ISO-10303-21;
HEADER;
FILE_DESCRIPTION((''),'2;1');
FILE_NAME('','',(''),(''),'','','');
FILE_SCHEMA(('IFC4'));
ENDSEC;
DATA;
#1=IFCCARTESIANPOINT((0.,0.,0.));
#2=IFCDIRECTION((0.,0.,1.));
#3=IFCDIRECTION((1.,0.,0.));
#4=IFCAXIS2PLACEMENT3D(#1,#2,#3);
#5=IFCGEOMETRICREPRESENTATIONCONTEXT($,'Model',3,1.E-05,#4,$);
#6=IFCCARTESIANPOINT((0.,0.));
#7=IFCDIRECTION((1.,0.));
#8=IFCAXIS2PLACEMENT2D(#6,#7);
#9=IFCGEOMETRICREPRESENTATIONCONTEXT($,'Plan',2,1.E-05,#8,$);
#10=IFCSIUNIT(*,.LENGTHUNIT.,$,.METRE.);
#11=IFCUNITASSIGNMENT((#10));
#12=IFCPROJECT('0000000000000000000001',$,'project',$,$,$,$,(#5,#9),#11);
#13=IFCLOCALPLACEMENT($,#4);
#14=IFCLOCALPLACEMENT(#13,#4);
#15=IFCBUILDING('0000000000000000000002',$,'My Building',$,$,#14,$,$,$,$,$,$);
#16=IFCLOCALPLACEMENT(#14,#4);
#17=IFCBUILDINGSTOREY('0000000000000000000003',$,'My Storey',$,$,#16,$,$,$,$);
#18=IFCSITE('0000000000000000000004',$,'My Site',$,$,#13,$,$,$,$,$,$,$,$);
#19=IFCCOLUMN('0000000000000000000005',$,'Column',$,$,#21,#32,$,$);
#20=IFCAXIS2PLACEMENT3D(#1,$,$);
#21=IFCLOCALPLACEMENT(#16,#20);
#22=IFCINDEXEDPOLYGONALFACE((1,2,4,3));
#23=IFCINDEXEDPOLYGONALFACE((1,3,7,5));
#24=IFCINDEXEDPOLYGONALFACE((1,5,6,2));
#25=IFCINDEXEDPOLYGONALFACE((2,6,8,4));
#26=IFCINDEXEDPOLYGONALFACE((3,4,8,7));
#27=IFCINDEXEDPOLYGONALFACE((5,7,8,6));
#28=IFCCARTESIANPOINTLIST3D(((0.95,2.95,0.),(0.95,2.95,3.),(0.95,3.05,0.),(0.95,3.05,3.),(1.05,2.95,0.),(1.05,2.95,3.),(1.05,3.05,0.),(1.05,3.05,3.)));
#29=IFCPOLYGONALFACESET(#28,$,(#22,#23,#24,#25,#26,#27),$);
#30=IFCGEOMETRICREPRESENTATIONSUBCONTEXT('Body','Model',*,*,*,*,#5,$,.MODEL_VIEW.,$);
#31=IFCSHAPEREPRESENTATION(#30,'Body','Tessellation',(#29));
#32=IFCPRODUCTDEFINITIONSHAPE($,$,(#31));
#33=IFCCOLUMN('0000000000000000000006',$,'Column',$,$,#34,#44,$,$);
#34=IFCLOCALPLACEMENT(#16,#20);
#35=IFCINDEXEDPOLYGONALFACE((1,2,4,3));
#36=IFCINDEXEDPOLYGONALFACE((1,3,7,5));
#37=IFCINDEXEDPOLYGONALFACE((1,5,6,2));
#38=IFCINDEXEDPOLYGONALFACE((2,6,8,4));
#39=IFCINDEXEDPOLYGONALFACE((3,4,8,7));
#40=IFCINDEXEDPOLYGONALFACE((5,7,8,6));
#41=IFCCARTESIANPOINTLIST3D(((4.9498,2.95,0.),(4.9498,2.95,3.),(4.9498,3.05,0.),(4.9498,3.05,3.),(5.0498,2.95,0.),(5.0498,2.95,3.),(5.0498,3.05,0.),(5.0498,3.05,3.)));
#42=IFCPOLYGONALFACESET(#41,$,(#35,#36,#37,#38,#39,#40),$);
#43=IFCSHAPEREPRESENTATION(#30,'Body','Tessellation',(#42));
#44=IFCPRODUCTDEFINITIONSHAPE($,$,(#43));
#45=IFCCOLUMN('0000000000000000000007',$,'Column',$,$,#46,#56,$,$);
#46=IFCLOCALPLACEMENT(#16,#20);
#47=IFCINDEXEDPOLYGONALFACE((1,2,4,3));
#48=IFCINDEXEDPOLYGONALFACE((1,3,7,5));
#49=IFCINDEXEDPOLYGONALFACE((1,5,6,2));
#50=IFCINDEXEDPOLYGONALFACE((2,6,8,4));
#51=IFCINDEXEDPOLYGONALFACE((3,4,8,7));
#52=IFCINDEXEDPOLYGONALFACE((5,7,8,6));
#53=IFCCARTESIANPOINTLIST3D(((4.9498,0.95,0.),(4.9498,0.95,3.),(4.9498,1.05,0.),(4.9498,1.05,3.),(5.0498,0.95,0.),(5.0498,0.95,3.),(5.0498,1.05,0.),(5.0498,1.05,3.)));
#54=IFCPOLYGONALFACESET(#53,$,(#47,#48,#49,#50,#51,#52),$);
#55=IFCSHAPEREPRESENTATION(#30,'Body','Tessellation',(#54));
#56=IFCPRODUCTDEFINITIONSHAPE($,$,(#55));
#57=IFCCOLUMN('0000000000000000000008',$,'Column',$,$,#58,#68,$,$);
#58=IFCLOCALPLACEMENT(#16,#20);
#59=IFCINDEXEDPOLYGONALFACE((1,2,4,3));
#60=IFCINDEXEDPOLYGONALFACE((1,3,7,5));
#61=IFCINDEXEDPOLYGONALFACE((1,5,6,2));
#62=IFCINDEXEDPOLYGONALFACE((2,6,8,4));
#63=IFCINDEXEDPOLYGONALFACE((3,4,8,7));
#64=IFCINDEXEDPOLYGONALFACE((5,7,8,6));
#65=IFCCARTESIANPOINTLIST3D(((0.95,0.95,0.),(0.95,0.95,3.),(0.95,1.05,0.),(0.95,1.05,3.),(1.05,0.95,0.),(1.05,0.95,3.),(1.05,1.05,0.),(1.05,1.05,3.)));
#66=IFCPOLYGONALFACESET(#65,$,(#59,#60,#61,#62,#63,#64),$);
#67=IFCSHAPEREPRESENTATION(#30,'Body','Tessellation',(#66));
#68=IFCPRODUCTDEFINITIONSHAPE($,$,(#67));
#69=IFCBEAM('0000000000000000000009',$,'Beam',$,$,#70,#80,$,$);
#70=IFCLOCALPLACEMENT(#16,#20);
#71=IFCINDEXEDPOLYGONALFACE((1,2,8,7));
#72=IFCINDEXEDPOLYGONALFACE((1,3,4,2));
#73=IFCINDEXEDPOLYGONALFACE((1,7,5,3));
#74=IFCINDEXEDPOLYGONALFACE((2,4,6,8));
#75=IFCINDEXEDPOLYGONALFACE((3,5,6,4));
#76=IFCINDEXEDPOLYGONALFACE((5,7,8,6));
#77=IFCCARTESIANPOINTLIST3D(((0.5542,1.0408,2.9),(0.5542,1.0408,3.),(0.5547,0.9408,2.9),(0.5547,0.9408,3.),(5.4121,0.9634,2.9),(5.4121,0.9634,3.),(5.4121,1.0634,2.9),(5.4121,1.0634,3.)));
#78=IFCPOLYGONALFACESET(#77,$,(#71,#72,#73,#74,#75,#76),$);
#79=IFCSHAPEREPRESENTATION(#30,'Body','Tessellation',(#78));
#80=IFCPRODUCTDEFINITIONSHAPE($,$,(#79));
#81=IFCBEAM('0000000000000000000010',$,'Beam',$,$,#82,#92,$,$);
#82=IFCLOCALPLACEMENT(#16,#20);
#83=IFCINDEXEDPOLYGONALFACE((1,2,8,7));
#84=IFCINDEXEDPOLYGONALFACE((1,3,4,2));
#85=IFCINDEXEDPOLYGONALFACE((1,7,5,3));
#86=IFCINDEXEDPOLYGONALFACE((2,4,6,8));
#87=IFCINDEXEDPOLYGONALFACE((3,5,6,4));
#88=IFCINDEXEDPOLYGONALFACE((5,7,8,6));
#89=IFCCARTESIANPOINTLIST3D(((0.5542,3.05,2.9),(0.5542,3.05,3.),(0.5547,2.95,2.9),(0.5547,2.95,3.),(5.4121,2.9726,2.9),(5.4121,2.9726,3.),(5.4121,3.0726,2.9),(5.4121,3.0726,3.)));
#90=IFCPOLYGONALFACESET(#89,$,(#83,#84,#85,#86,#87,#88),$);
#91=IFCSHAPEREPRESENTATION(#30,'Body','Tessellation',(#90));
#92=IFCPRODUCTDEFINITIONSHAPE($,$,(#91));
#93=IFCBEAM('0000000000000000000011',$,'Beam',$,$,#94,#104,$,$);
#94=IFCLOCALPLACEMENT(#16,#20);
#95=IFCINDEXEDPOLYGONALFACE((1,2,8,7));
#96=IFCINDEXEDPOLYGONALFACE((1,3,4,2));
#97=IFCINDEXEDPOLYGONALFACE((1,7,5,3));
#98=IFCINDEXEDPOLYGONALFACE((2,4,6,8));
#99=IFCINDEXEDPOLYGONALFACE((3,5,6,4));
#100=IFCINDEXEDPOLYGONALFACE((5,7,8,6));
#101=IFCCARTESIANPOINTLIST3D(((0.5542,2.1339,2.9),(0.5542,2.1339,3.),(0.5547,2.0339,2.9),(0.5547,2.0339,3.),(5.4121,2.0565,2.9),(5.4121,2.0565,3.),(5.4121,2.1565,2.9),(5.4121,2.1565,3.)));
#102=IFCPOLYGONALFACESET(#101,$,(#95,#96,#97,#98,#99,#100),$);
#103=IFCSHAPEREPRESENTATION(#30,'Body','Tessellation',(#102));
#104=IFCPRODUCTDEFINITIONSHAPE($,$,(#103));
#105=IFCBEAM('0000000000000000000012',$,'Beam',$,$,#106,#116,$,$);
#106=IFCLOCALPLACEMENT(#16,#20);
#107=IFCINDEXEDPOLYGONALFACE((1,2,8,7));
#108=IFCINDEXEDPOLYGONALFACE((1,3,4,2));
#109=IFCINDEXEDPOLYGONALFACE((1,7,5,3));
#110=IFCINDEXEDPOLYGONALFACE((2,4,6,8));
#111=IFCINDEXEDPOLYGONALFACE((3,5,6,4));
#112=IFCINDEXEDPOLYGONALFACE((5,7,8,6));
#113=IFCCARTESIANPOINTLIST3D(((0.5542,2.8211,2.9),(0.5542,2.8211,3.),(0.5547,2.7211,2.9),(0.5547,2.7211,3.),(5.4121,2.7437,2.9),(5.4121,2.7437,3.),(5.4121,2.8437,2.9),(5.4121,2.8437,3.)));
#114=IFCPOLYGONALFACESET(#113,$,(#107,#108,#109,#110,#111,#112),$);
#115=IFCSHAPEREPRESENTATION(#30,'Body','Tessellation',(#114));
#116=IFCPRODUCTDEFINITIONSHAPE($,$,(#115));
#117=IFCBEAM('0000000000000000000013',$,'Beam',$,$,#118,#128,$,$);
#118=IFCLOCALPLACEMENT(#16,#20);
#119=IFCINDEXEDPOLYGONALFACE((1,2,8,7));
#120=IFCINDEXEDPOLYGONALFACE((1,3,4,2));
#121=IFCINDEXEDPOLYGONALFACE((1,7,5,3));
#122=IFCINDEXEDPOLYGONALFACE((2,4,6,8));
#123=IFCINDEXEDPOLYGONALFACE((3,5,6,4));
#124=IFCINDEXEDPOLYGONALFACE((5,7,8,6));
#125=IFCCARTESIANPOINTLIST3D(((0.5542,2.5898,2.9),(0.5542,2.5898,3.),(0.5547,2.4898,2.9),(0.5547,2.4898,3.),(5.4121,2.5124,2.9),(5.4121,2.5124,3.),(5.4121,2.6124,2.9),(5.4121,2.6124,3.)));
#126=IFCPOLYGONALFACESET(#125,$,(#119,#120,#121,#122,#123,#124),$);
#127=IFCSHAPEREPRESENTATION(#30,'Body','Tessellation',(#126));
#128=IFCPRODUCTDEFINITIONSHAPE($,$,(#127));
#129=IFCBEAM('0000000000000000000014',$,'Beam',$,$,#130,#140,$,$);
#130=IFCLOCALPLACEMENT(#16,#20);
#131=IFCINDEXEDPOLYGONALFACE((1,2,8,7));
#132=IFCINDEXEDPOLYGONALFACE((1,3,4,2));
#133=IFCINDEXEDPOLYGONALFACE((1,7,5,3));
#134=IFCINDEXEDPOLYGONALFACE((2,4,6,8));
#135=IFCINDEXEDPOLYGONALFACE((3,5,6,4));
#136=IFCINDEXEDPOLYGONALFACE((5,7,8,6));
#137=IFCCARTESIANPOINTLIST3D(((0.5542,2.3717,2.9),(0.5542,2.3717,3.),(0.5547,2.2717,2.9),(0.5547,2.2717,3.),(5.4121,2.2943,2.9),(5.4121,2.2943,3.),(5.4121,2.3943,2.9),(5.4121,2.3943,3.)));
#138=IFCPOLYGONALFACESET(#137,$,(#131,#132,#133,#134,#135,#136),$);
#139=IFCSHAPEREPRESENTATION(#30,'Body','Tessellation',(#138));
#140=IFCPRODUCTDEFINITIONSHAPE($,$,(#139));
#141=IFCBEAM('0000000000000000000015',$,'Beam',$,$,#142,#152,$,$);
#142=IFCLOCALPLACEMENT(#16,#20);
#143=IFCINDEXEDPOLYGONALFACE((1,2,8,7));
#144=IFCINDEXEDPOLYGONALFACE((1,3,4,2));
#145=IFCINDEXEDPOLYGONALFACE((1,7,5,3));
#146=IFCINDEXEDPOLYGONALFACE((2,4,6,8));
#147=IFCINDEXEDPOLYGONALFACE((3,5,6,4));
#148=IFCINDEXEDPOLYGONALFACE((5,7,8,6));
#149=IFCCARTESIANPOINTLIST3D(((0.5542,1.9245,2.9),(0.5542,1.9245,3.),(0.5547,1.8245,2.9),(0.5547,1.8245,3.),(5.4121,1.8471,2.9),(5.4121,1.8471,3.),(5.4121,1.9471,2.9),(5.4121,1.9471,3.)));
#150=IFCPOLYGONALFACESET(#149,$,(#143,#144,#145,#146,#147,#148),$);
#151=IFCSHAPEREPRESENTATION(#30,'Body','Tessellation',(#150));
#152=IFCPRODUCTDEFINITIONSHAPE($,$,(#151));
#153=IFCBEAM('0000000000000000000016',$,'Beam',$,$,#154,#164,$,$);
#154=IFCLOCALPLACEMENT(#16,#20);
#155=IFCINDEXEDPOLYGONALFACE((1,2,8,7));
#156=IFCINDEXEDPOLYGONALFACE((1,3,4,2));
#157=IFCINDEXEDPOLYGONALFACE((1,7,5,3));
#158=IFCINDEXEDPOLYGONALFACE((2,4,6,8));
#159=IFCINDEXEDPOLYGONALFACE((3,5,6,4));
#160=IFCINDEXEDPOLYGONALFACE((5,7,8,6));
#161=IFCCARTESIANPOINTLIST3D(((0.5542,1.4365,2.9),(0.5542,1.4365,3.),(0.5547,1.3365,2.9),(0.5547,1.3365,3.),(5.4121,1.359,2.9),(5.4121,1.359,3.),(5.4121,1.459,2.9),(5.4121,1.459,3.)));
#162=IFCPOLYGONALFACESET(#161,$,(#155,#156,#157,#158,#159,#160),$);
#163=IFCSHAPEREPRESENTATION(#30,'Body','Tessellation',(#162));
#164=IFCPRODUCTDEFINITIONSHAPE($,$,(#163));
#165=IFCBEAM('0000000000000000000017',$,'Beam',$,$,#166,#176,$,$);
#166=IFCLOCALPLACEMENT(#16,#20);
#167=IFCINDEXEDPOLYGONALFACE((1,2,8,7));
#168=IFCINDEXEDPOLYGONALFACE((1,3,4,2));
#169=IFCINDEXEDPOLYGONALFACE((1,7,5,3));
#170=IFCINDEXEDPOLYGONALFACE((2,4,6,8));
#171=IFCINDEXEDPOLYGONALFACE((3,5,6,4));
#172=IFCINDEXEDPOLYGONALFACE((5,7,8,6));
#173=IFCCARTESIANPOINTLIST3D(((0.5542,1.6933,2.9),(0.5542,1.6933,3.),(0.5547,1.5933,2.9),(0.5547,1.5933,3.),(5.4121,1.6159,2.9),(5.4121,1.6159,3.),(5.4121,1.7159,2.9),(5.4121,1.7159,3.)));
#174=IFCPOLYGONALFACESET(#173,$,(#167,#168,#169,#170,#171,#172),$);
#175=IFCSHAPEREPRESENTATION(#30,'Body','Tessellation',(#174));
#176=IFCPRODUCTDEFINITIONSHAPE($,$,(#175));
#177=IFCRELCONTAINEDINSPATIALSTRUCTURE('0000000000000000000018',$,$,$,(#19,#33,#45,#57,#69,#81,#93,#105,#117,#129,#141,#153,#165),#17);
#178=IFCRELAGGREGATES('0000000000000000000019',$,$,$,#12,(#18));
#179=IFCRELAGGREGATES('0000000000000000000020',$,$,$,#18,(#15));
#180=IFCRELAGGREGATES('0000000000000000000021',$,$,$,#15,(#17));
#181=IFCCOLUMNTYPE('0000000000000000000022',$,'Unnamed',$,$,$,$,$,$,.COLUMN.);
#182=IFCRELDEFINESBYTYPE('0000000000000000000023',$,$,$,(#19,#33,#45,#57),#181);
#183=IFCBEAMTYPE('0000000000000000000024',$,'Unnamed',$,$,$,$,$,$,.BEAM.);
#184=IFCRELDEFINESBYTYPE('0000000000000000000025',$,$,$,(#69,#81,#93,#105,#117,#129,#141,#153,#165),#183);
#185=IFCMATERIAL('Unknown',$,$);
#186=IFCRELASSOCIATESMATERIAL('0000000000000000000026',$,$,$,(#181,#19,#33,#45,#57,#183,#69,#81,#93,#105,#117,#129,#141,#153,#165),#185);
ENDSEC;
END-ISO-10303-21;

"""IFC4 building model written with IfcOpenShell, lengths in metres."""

from ifc_helpers import new_model, si_unit, frame, origin_with_axes, origin_2d_with_axis, place, context, subcontext, project, spatial, rectangle, extrude, clip, halfspace, material, material_profile, profile_set, profile_usage, type_object, element, save


model = new_model("IFC4")

# Units and contexts
model_context = context("Model", 3, precision=1e-05, world=origin_with_axes())
plan_context = context("Plan", 2, precision=1e-05, world=origin_2d_with_axis())
body_context = subcontext(model_context, "Body", "Model", "MODEL_VIEW")
ifc_project = project(units=[si_unit("LENGTHUNIT", "METRE")], contexts=[model_context, plan_context])

# Site, building, storey
site_placement = place(None, origin_with_axes())
site = spatial("IfcSite", under=ifc_project, at=site_placement, Name="My Site")
building_placement = place(site_placement, origin_with_axes())
building = spatial("IfcBuilding", under=site, at=building_placement, Name="My Building")
storey_placement = place(building_placement, origin_with_axes())
storey = spatial("IfcBuildingStorey", under=building, at=storey_placement, Name="My Storey")

# Columns
ifc_material = material(Name="Unknown")
ifc_material_profile_1 = material_profile(ifc_material, rectangle(XDim=0.1, YDim=0.1))
ifc_profile_set_1 = profile_set([ifc_material_profile_1])
ifc_profile_usage_1 = profile_usage(ifc_profile_set_1, cardinal=5)
column_type = type_object("IfcColumnType", Name="Unnamed", PredefinedType="COLUMN", material=ifc_profile_set_1)
column_1_placement = place(storey_placement, frame((1.0, 3.0, 0.0), z_axis=(0.0, 0.0, 1.0), x_axis=(1.0, 0.0, 0.0)))
element("IfcColumn", 1, at=column_1_placement, inside=storey, type_object=column_type, material=ifc_profile_usage_1, Name="Column", context=body_context, shape_type="SweptSolid", body=[
    extrude(rectangle(XDim=0.1, YDim=0.1), origin_with_axes(), (0.0, 0.0, 1.0), 3.0),
])
ifc_profile_usage_2 = profile_usage(ifc_profile_set_1, cardinal=5)
column_2_placement = place(storey_placement, frame((4.9998, 3.0, 0.0), z_axis=(0.0, 0.0, 1.0), x_axis=(1.0, 0.0, 0.0)))
element("IfcColumn", 2, at=column_2_placement, inside=storey, type_object=column_type, material=ifc_profile_usage_2, Name="Column", context=body_context, shape_type="SweptSolid", body=[
    extrude(rectangle(XDim=0.1, YDim=0.1), origin_with_axes(), (0.0, 0.0, 1.0), 3.0),
])
ifc_profile_usage_3 = profile_usage(ifc_profile_set_1, cardinal=5)
column_3_placement = place(storey_placement, frame((4.9998, 1.0, 0.0), z_axis=(0.0, 0.0, 1.0), x_axis=(1.0, 0.0, 0.0)))
element("IfcColumn", 3, at=column_3_placement, inside=storey, type_object=column_type, material=ifc_profile_usage_3, Name="Column", context=body_context, shape_type="SweptSolid", body=[
    extrude(rectangle(XDim=0.1, YDim=0.1), origin_with_axes(), (0.0, 0.0, 1.0), 3.0),
])
ifc_profile_usage_4 = profile_usage(ifc_profile_set_1, cardinal=5)
column_4_placement = place(storey_placement, frame((1.0, 1.0, 0.0), z_axis=(0.0, 0.0, 1.0), x_axis=(1.0, 0.0, 0.0)))
element("IfcColumn", 4, at=column_4_placement, inside=storey, type_object=column_type, material=ifc_profile_usage_4, Name="Column", context=body_context, shape_type="SweptSolid", body=[
    extrude(rectangle(XDim=0.1, YDim=0.1), origin_with_axes(), (0.0, 0.0, 1.0), 3.0),
])

# Beams
ifc_material_profile_2 = material_profile(ifc_material, rectangle(XDim=0.1, YDim=0.1))
ifc_profile_set_2 = profile_set([ifc_material_profile_2])
ifc_profile_usage_5 = profile_usage(ifc_profile_set_2, cardinal=7)
beam_type = type_object("IfcBeamType", Name="Unnamed", PredefinedType="BEAM", material=ifc_profile_set_2)
beam_1_placement = place(storey_placement, frame((0.5542, 1.0408, 3.0), z_axis=(0.999989, 0.004651, 0.0), x_axis=(-0.004651, 0.999989, 0.0)))
element("IfcBeam", 5, at=beam_1_placement, inside=storey, type_object=beam_type, material=ifc_profile_usage_5, Name="Beam", context=body_context, shape_type="Clipping", body=[
    clip(extrude(rectangle(XDim=0.1, YDim=0.1), frame((-0.05, -0.05, 0.0), z_axis=(0.0, 0.0, 1.0), x_axis=(1.0, 0.0, 0.0)), (0.0, 0.0, 1.0), 4.9579), halfspace(frame((1.9865, -3.0, 4.8672), z_axis=(-0.004651, 0.0, 0.999989), x_axis=(-0.999989, 0.0, -0.004651)), False)),
])
ifc_profile_usage_6 = profile_usage(ifc_profile_set_2, cardinal=7)
beam_2_placement = place(storey_placement, frame((0.5542, 3.05, 3.0), z_axis=(0.999989, 0.004651, 0.0), x_axis=(-0.004651, 0.999989, 0.0)))
element("IfcBeam", 6, at=beam_2_placement, inside=storey, type_object=beam_type, material=ifc_profile_usage_6, Name="Beam", context=body_context, shape_type="Clipping", body=[
    clip(extrude(rectangle(XDim=0.1, YDim=0.1), frame((-0.05, -0.05, 0.0), z_axis=(0.0, 0.0, 1.0), x_axis=(1.0, 0.0, 0.0)), (0.0, 0.0, 1.0), 4.9579), halfspace(frame((-0.0226, -3.0, 4.8578), z_axis=(-0.004651, 0.0, 0.999989), x_axis=(-0.999989, 0.0, -0.004651)), False)),
])
ifc_profile_usage_7 = profile_usage(ifc_profile_set_2, cardinal=7)
beam_3_placement = place(storey_placement, frame((0.5542, 2.1339, 3.0), z_axis=(0.999989, 0.004651, 0.0), x_axis=(-0.004651, 0.999989, 0.0)))
element("IfcBeam", 7, at=beam_3_placement, inside=storey, type_object=beam_type, material=ifc_profile_usage_7, Name="Beam", context=body_context, shape_type="Clipping", body=[
    clip(extrude(rectangle(XDim=0.1, YDim=0.1), frame((-0.05, -0.05, 0.0), z_axis=(0.0, 0.0, 1.0), x_axis=(1.0, 0.0, 0.0)), (0.0, 0.0, 1.0), 4.9579), halfspace(frame((0.8935, -3.0, 4.8621), z_axis=(-0.004651, 0.0, 0.999989), x_axis=(-0.999989, 0.0, -0.004651)), False)),
])
ifc_profile_usage_8 = profile_usage(ifc_profile_set_2, cardinal=7)
beam_4_placement = place(storey_placement, frame((0.5542, 2.8211, 3.0), z_axis=(0.999989, 0.004651, 0.0), x_axis=(-0.004651, 0.999989, 0.0)))
element("IfcBeam", 8, at=beam_4_placement, inside=storey, type_object=beam_type, material=ifc_profile_usage_8, Name="Beam", context=body_context, shape_type="Clipping", body=[
    clip(extrude(rectangle(XDim=0.1, YDim=0.1), frame((-0.05, -0.05, 0.0), z_axis=(0.0, 0.0, 1.0), x_axis=(1.0, 0.0, 0.0)), (0.0, 0.0, 1.0), 4.9579), halfspace(frame((0.2063, -3.0, 4.8589), z_axis=(-0.004651, 0.0, 0.999989), x_axis=(-0.999989, 0.0, -0.004651)), False)),
])
ifc_profile_usage_9 = profile_usage(ifc_profile_set_2, cardinal=7)
beam_5_placement = place(storey_placement, frame((0.5542, 2.5898, 3.0), z_axis=(0.999989, 0.004651, 0.0), x_axis=(-0.004651, 0.999989, 0.0)))
element("IfcBeam", 9, at=beam_5_placement, inside=storey, type_object=beam_type, material=ifc_profile_usage_9, Name="Beam", context=body_context, shape_type="Clipping", body=[
    clip(extrude(rectangle(XDim=0.1, YDim=0.1), frame((-0.05, -0.05, 0.0), z_axis=(0.0, 0.0, 1.0), x_axis=(1.0, 0.0, 0.0)), (0.0, 0.0, 1.0), 4.9579), halfspace(frame((0.4376, -3.0, 4.86), z_axis=(-0.004651, 0.0, 0.999989), x_axis=(-0.999989, 0.0, -0.004651)), False)),
])
ifc_profile_usage_10 = profile_usage(ifc_profile_set_2, cardinal=7)
beam_6_placement = place(storey_placement, frame((0.5542, 2.3717, 3.0), z_axis=(0.999989, 0.004651, 0.0), x_axis=(-0.004651, 0.999989, 0.0)))
element("IfcBeam", 10, at=beam_6_placement, inside=storey, type_object=beam_type, material=ifc_profile_usage_10, Name="Beam", context=body_context, shape_type="Clipping", body=[
    clip(extrude(rectangle(XDim=0.1, YDim=0.1), frame((-0.05, -0.05, 0.0), z_axis=(0.0, 0.0, 1.0), x_axis=(1.0, 0.0, 0.0)), (0.0, 0.0, 1.0), 4.9579), halfspace(frame((0.6557, -3.0, 4.861), z_axis=(-0.004651, 0.0, 0.999989), x_axis=(-0.999989, 0.0, -0.004651)), False)),
])
ifc_profile_usage_11 = profile_usage(ifc_profile_set_2, cardinal=7)
beam_7_placement = place(storey_placement, frame((0.5542, 1.9245, 3.0), z_axis=(0.999989, 0.004651, 0.0), x_axis=(-0.004651, 0.999989, 0.0)))
element("IfcBeam", 11, at=beam_7_placement, inside=storey, type_object=beam_type, material=ifc_profile_usage_11, Name="Beam", context=body_context, shape_type="Clipping", body=[
    clip(extrude(rectangle(XDim=0.1, YDim=0.1), frame((-0.05, -0.05, 0.0), z_axis=(0.0, 0.0, 1.0), x_axis=(1.0, 0.0, 0.0)), (0.0, 0.0, 1.0), 4.9579), halfspace(frame((1.1029, -3.0, 4.8631), z_axis=(-0.004651, 0.0, 0.999989), x_axis=(-0.999989, 0.0, -0.004651)), False)),
])
ifc_profile_usage_12 = profile_usage(ifc_profile_set_2, cardinal=7)
beam_8_placement = place(storey_placement, frame((0.5542, 1.4365, 3.0), z_axis=(0.999989, 0.004651, 0.0), x_axis=(-0.004651, 0.999989, 0.0)))
element("IfcBeam", 12, at=beam_8_placement, inside=storey, type_object=beam_type, material=ifc_profile_usage_12, Name="Beam", context=body_context, shape_type="Clipping", body=[
    clip(extrude(rectangle(XDim=0.1, YDim=0.1), frame((-0.05, -0.05, 0.0), z_axis=(0.0, 0.0, 1.0), x_axis=(1.0, 0.0, 0.0)), (0.0, 0.0, 1.0), 4.9579), halfspace(frame((1.5909, -3.0, 4.8653), z_axis=(-0.004651, 0.0, 0.999989), x_axis=(-0.999989, 0.0, -0.004651)), False)),
])
ifc_profile_usage_13 = profile_usage(ifc_profile_set_2, cardinal=7)
beam_9_placement = place(storey_placement, frame((0.5542, 1.6933, 3.0), z_axis=(0.999989, 0.004651, 0.0), x_axis=(-0.004651, 0.999989, 0.0)))
element("IfcBeam", 13, at=beam_9_placement, inside=storey, type_object=beam_type, material=ifc_profile_usage_13, Name="Beam", context=body_context, shape_type="Clipping", body=[
    clip(extrude(rectangle(XDim=0.1, YDim=0.1), frame((-0.05, -0.05, 0.0), z_axis=(0.0, 0.0, 1.0), x_axis=(1.0, 0.0, 0.0)), (0.0, 0.0, 1.0), 4.9579), halfspace(frame((1.3341, -3.0, 4.8642), z_axis=(-0.004651, 0.0, 0.999989), x_axis=(-0.999989, 0.0, -0.004651)), False)),
])

save(model, "model.ifc")
